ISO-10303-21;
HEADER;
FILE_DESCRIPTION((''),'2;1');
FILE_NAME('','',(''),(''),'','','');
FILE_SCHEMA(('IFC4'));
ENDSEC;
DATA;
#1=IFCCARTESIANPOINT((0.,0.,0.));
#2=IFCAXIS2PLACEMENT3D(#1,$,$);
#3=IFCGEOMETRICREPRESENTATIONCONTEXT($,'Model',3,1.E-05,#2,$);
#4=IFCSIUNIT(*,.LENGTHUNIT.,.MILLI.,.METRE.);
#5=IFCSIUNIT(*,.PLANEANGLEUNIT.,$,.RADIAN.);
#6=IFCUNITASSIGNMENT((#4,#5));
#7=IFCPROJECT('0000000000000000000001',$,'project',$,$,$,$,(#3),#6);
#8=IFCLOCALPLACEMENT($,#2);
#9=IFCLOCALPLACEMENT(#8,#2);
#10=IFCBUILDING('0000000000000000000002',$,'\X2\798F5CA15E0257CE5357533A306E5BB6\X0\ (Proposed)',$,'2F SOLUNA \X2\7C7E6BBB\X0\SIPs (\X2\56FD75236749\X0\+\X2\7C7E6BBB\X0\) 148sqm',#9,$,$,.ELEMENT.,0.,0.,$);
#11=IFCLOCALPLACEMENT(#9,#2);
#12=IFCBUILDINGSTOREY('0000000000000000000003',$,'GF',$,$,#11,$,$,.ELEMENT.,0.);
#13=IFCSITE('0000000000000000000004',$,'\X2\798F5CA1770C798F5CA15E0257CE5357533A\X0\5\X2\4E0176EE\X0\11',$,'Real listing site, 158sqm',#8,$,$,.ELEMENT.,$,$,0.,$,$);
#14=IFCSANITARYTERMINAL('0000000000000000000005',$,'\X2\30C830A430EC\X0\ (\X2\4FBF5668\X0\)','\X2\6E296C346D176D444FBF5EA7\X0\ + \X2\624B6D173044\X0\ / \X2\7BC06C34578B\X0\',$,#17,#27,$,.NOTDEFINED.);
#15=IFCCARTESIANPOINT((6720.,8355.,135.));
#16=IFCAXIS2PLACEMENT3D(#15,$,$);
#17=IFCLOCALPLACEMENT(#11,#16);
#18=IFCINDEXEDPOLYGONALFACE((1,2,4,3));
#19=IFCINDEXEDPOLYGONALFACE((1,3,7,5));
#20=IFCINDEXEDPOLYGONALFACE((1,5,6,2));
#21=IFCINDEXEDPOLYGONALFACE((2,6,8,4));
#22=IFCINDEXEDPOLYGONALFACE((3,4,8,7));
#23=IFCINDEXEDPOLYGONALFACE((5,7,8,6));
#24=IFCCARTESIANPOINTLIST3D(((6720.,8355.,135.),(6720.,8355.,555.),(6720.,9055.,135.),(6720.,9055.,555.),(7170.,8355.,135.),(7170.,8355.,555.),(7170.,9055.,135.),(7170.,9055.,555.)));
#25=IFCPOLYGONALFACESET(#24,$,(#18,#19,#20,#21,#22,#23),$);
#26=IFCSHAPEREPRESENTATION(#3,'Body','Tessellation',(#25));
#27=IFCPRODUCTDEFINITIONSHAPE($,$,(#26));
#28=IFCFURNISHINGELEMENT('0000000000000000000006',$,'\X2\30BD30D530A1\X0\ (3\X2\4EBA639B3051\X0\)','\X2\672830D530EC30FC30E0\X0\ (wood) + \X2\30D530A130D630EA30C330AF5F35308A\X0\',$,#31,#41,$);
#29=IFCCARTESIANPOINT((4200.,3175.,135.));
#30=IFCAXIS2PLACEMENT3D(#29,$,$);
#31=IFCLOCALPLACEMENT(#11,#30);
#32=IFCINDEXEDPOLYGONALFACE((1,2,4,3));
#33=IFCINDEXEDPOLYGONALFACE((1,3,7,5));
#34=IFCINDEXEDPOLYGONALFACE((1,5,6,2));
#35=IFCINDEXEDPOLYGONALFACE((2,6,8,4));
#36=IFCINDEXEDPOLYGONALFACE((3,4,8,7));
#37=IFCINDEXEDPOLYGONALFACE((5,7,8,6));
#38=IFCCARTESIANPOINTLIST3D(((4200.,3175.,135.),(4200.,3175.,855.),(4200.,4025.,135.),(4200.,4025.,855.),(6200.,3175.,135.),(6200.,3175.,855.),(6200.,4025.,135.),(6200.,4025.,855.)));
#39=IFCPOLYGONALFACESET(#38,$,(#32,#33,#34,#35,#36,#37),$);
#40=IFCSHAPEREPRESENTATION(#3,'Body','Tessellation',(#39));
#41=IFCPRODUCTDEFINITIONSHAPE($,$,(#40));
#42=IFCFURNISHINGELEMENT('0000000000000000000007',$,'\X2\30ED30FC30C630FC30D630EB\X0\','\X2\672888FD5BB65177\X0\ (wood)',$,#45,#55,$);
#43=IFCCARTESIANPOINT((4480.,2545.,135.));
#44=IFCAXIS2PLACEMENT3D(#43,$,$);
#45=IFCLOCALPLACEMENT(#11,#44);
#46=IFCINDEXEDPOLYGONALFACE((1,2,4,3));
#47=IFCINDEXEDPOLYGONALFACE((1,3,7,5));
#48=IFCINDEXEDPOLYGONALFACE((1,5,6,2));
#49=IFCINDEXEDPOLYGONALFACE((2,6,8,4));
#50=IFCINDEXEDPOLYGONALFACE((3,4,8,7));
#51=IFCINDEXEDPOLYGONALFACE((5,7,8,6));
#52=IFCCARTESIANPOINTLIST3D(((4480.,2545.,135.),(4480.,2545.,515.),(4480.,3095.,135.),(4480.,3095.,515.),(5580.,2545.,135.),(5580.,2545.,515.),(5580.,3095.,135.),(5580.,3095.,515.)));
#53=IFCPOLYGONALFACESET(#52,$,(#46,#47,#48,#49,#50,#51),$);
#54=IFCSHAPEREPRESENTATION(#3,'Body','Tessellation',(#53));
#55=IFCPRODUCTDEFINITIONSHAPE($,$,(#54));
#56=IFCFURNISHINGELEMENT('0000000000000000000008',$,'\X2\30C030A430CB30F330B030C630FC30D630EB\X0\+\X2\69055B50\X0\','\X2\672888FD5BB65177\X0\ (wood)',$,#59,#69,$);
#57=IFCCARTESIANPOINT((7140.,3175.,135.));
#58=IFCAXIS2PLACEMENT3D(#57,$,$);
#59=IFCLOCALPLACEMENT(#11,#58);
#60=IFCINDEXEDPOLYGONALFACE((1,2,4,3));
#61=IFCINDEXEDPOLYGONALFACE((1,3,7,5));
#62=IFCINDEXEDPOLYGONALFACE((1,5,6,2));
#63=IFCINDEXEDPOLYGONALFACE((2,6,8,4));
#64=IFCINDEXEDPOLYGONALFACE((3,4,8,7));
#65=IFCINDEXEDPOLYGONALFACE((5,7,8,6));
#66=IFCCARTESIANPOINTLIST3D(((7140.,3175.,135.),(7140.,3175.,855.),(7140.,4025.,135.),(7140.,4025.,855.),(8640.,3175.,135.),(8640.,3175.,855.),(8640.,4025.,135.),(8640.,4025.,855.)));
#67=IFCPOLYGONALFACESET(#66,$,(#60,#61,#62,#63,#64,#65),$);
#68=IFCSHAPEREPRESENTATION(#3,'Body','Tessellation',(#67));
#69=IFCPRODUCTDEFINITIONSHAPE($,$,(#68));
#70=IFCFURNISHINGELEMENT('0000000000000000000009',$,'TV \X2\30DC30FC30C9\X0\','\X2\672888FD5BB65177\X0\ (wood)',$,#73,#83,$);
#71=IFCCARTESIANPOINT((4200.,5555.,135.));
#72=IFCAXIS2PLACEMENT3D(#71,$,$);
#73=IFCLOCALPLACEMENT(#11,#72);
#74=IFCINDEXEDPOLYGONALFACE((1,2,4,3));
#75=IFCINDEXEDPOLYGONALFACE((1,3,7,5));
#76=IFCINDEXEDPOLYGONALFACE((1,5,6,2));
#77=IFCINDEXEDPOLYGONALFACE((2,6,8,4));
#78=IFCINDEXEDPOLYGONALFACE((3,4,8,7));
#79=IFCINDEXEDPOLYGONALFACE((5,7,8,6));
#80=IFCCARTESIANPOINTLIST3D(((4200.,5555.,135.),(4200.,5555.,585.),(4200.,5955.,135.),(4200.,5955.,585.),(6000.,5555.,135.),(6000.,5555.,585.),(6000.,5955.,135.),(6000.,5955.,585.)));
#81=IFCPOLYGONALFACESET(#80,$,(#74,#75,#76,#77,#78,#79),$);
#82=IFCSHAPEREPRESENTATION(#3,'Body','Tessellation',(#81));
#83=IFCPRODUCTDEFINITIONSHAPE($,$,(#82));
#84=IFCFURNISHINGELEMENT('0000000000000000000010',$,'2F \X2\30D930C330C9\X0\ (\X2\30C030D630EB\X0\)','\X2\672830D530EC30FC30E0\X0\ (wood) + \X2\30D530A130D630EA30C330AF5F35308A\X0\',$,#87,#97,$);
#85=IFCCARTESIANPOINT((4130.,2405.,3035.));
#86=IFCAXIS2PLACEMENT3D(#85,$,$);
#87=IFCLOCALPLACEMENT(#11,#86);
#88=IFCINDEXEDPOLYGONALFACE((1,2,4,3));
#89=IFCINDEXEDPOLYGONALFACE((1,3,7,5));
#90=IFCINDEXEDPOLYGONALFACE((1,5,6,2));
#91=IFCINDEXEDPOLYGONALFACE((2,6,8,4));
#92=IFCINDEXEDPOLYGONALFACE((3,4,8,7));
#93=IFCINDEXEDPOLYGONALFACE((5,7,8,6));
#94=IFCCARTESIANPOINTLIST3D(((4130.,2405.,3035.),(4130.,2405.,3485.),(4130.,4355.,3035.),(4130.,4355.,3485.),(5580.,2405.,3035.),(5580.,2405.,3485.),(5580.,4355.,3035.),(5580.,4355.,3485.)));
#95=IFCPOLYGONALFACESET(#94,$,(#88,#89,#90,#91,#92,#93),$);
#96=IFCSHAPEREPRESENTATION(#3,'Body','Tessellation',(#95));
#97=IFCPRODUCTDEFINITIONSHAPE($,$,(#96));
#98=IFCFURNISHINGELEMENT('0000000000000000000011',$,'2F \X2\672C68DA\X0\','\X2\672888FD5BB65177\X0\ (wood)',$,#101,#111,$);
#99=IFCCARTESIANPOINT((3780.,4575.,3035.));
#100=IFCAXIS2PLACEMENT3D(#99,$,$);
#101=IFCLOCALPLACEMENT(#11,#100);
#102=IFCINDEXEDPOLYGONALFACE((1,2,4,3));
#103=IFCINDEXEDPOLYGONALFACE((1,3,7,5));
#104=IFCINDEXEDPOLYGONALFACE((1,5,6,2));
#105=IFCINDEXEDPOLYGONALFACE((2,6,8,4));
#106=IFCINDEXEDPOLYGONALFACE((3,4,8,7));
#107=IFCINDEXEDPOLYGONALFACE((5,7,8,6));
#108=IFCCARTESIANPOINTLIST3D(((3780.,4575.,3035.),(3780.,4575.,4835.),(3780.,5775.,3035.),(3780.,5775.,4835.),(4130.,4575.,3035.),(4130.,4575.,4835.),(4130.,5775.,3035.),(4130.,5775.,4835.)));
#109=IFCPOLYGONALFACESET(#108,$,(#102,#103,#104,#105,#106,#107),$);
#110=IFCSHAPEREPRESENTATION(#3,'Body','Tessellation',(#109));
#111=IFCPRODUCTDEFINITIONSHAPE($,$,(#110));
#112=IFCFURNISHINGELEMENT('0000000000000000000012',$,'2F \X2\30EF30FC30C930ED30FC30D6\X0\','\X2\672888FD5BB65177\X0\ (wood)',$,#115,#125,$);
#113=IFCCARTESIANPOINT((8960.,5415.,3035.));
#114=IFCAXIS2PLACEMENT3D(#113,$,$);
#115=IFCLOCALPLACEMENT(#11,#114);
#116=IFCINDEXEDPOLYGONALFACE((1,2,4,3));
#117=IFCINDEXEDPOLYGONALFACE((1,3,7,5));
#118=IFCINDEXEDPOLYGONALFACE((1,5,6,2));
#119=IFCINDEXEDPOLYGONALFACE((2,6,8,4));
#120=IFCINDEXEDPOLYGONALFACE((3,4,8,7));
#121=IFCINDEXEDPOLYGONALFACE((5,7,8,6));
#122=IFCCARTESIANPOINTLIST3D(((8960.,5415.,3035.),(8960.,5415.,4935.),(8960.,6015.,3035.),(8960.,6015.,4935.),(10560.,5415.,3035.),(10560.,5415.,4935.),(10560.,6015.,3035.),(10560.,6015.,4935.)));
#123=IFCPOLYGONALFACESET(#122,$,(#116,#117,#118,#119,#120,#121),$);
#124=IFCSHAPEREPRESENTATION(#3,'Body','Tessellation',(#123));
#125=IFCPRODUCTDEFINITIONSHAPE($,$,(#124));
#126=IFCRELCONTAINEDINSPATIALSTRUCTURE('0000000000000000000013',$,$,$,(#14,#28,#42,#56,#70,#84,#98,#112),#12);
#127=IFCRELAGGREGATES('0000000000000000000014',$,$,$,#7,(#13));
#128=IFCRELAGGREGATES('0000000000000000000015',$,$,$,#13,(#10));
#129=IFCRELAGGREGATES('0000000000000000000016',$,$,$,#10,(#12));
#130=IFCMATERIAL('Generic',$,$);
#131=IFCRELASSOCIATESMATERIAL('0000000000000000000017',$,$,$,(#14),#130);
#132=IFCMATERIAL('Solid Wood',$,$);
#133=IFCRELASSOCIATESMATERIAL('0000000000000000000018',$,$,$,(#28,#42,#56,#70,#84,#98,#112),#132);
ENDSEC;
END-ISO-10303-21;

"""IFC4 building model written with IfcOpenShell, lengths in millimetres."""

from ifc_helpers import new_model, si_unit, frame, frame_2d, origin, place, context, project, spatial, rectangle, extrude, material, element, save


model = new_model("IFC4")

# Units and contexts
model_context = context("Model", 3, precision=1e-05, world=origin())
ifc_project = project(units=[si_unit("LENGTHUNIT", "METRE", prefix="MILLI"), si_unit("PLANEANGLEUNIT", "RADIAN")], contexts=[model_context])

# Site, building, storey
site_placement = place(None, origin())
site = spatial("IfcSite", under=ifc_project, at=site_placement, Name="福岡県福岡市城南区5丁目11", ObjectType="Real listing site, 158sqm", CompositionType="ELEMENT", RefElevation=0.0)
building_placement = place(site_placement, origin())
building = spatial("IfcBuilding", under=site, at=building_placement, Name="福岡市城南区の家 (Proposed)", ObjectType="2F SOLUNA 籾殻SIPs (国産杉+籾殻) 148sqm", CompositionType="ELEMENT", ElevationOfRefHeight=0.0, ElevationOfTerrain=0.0)
storey_placement = place(building_placement, origin())
storey = spatial("IfcBuildingStorey", under=building, at=storey_placement, Name="GF", CompositionType="ELEMENT", Elevation=0.0)

# Shared definitions
ifc_material_1 = material(Name="Solid Wood")

# Shared definitions
ifc_material_2 = material(Name="Generic")

# Sanitary terminal
sanitary_terminal_1_placement = place(storey_placement, frame((6720.0, 8355.0, 135.0)))
element("IfcSanitaryTerminal", 1, at=sanitary_terminal_1_placement, inside=storey, material=ifc_material_2, Name="トイレ (便器)", Description="温水洗浄便座 + 手洗い / 節水型", PredefinedType="NOTDEFINED", context=model_context, shape_type="SweptSolid", body=[
    extrude(rectangle(XDim=450.0, YDim=700.0, at=frame_2d((225.0, 350.0))), frame((6720.0, 8355.0, 135.0)), (0.0, 0.0, 1.0), 420.0),
])

# Furnishing elements
furnishing_1_placement = place(storey_placement, frame((4200.0, 3175.0, 135.0)))
element("IfcFurnishingElement", 2, at=furnishing_1_placement, inside=storey, material=ifc_material_1, Name="ソファ (3人掛け)", Description="木フレーム (wood) + ファブリック張り", context=model_context, shape_type="SweptSolid", body=[
    extrude(rectangle(XDim=2000.0, YDim=850.0, at=frame_2d((1000.0, 425.0))), frame((4200.0, 3175.0, 135.0)), (0.0, 0.0, 1.0), 720.0),
])
furnishing_2_placement = place(storey_placement, frame((4480.0, 2545.0, 135.0)))
element("IfcFurnishingElement", 3, at=furnishing_2_placement, inside=storey, material=ifc_material_1, Name="ローテーブル", Description="木製家具 (wood)", context=model_context, shape_type="SweptSolid", body=[
    extrude(rectangle(XDim=1100.0, YDim=550.0, at=frame_2d((550.0, 275.0))), frame((4480.0, 2545.0, 135.0)), (0.0, 0.0, 1.0), 380.0),
])
furnishing_3_placement = place(storey_placement, frame((7140.0, 3175.0, 135.0)))
element("IfcFurnishingElement", 4, at=furnishing_3_placement, inside=storey, material=ifc_material_1, Name="ダイニングテーブル+椅子", Description="木製家具 (wood)", context=model_context, shape_type="SweptSolid", body=[
    extrude(rectangle(XDim=1500.0, YDim=850.0, at=frame_2d((750.0, 425.0))), frame((7140.0, 3175.0, 135.0)), (0.0, 0.0, 1.0), 720.0),
])
furnishing_4_placement = place(storey_placement, frame((4200.0, 5555.0, 135.0)))
element("IfcFurnishingElement", 5, at=furnishing_4_placement, inside=storey, material=ifc_material_1, Name="TV ボード", Description="木製家具 (wood)", context=model_context, shape_type="SweptSolid", body=[
    extrude(rectangle(XDim=1800.0, YDim=400.0, at=frame_2d((900.0, 200.0))), frame((4200.0, 5555.0, 135.0)), (0.0, 0.0, 1.0), 450.0),
])
furnishing_5_placement = place(storey_placement, frame((4130.0, 2405.0, 3035.0)))
element("IfcFurnishingElement", 6, at=furnishing_5_placement, inside=storey, material=ifc_material_1, Name="2F ベッド (ダブル)", Description="木フレーム (wood) + ファブリック張り", context=model_context, shape_type="SweptSolid", body=[
    extrude(rectangle(XDim=1450.0, YDim=1950.0, at=frame_2d((725.0, 975.0))), frame((4130.0, 2405.0, 3035.0)), (0.0, 0.0, 1.0), 450.0),
])
furnishing_6_placement = place(storey_placement, frame((3780.0, 4575.0, 3035.0)))
element("IfcFurnishingElement", 7, at=furnishing_6_placement, inside=storey, material=ifc_material_1, Name="2F 本棚", Description="木製家具 (wood)", context=model_context, shape_type="SweptSolid", body=[
    extrude(rectangle(XDim=350.0, YDim=1200.0, at=frame_2d((175.0, 600.0))), frame((3780.0, 4575.0, 3035.0)), (0.0, 0.0, 1.0), 1800.0),
])
furnishing_7_placement = place(storey_placement, frame((8960.0, 5415.0, 3035.0)))
element("IfcFurnishingElement", 8, at=furnishing_7_placement, inside=storey, material=ifc_material_1, Name="2F ワードローブ", Description="木製家具 (wood)", context=model_context, shape_type="SweptSolid", body=[
    extrude(rectangle(XDim=1600.0, YDim=600.0, at=frame_2d((800.0, 300.0))), frame((8960.0, 5415.0, 3035.0)), (0.0, 0.0, 1.0), 1900.0),
])

save(model, "model.ifc")
